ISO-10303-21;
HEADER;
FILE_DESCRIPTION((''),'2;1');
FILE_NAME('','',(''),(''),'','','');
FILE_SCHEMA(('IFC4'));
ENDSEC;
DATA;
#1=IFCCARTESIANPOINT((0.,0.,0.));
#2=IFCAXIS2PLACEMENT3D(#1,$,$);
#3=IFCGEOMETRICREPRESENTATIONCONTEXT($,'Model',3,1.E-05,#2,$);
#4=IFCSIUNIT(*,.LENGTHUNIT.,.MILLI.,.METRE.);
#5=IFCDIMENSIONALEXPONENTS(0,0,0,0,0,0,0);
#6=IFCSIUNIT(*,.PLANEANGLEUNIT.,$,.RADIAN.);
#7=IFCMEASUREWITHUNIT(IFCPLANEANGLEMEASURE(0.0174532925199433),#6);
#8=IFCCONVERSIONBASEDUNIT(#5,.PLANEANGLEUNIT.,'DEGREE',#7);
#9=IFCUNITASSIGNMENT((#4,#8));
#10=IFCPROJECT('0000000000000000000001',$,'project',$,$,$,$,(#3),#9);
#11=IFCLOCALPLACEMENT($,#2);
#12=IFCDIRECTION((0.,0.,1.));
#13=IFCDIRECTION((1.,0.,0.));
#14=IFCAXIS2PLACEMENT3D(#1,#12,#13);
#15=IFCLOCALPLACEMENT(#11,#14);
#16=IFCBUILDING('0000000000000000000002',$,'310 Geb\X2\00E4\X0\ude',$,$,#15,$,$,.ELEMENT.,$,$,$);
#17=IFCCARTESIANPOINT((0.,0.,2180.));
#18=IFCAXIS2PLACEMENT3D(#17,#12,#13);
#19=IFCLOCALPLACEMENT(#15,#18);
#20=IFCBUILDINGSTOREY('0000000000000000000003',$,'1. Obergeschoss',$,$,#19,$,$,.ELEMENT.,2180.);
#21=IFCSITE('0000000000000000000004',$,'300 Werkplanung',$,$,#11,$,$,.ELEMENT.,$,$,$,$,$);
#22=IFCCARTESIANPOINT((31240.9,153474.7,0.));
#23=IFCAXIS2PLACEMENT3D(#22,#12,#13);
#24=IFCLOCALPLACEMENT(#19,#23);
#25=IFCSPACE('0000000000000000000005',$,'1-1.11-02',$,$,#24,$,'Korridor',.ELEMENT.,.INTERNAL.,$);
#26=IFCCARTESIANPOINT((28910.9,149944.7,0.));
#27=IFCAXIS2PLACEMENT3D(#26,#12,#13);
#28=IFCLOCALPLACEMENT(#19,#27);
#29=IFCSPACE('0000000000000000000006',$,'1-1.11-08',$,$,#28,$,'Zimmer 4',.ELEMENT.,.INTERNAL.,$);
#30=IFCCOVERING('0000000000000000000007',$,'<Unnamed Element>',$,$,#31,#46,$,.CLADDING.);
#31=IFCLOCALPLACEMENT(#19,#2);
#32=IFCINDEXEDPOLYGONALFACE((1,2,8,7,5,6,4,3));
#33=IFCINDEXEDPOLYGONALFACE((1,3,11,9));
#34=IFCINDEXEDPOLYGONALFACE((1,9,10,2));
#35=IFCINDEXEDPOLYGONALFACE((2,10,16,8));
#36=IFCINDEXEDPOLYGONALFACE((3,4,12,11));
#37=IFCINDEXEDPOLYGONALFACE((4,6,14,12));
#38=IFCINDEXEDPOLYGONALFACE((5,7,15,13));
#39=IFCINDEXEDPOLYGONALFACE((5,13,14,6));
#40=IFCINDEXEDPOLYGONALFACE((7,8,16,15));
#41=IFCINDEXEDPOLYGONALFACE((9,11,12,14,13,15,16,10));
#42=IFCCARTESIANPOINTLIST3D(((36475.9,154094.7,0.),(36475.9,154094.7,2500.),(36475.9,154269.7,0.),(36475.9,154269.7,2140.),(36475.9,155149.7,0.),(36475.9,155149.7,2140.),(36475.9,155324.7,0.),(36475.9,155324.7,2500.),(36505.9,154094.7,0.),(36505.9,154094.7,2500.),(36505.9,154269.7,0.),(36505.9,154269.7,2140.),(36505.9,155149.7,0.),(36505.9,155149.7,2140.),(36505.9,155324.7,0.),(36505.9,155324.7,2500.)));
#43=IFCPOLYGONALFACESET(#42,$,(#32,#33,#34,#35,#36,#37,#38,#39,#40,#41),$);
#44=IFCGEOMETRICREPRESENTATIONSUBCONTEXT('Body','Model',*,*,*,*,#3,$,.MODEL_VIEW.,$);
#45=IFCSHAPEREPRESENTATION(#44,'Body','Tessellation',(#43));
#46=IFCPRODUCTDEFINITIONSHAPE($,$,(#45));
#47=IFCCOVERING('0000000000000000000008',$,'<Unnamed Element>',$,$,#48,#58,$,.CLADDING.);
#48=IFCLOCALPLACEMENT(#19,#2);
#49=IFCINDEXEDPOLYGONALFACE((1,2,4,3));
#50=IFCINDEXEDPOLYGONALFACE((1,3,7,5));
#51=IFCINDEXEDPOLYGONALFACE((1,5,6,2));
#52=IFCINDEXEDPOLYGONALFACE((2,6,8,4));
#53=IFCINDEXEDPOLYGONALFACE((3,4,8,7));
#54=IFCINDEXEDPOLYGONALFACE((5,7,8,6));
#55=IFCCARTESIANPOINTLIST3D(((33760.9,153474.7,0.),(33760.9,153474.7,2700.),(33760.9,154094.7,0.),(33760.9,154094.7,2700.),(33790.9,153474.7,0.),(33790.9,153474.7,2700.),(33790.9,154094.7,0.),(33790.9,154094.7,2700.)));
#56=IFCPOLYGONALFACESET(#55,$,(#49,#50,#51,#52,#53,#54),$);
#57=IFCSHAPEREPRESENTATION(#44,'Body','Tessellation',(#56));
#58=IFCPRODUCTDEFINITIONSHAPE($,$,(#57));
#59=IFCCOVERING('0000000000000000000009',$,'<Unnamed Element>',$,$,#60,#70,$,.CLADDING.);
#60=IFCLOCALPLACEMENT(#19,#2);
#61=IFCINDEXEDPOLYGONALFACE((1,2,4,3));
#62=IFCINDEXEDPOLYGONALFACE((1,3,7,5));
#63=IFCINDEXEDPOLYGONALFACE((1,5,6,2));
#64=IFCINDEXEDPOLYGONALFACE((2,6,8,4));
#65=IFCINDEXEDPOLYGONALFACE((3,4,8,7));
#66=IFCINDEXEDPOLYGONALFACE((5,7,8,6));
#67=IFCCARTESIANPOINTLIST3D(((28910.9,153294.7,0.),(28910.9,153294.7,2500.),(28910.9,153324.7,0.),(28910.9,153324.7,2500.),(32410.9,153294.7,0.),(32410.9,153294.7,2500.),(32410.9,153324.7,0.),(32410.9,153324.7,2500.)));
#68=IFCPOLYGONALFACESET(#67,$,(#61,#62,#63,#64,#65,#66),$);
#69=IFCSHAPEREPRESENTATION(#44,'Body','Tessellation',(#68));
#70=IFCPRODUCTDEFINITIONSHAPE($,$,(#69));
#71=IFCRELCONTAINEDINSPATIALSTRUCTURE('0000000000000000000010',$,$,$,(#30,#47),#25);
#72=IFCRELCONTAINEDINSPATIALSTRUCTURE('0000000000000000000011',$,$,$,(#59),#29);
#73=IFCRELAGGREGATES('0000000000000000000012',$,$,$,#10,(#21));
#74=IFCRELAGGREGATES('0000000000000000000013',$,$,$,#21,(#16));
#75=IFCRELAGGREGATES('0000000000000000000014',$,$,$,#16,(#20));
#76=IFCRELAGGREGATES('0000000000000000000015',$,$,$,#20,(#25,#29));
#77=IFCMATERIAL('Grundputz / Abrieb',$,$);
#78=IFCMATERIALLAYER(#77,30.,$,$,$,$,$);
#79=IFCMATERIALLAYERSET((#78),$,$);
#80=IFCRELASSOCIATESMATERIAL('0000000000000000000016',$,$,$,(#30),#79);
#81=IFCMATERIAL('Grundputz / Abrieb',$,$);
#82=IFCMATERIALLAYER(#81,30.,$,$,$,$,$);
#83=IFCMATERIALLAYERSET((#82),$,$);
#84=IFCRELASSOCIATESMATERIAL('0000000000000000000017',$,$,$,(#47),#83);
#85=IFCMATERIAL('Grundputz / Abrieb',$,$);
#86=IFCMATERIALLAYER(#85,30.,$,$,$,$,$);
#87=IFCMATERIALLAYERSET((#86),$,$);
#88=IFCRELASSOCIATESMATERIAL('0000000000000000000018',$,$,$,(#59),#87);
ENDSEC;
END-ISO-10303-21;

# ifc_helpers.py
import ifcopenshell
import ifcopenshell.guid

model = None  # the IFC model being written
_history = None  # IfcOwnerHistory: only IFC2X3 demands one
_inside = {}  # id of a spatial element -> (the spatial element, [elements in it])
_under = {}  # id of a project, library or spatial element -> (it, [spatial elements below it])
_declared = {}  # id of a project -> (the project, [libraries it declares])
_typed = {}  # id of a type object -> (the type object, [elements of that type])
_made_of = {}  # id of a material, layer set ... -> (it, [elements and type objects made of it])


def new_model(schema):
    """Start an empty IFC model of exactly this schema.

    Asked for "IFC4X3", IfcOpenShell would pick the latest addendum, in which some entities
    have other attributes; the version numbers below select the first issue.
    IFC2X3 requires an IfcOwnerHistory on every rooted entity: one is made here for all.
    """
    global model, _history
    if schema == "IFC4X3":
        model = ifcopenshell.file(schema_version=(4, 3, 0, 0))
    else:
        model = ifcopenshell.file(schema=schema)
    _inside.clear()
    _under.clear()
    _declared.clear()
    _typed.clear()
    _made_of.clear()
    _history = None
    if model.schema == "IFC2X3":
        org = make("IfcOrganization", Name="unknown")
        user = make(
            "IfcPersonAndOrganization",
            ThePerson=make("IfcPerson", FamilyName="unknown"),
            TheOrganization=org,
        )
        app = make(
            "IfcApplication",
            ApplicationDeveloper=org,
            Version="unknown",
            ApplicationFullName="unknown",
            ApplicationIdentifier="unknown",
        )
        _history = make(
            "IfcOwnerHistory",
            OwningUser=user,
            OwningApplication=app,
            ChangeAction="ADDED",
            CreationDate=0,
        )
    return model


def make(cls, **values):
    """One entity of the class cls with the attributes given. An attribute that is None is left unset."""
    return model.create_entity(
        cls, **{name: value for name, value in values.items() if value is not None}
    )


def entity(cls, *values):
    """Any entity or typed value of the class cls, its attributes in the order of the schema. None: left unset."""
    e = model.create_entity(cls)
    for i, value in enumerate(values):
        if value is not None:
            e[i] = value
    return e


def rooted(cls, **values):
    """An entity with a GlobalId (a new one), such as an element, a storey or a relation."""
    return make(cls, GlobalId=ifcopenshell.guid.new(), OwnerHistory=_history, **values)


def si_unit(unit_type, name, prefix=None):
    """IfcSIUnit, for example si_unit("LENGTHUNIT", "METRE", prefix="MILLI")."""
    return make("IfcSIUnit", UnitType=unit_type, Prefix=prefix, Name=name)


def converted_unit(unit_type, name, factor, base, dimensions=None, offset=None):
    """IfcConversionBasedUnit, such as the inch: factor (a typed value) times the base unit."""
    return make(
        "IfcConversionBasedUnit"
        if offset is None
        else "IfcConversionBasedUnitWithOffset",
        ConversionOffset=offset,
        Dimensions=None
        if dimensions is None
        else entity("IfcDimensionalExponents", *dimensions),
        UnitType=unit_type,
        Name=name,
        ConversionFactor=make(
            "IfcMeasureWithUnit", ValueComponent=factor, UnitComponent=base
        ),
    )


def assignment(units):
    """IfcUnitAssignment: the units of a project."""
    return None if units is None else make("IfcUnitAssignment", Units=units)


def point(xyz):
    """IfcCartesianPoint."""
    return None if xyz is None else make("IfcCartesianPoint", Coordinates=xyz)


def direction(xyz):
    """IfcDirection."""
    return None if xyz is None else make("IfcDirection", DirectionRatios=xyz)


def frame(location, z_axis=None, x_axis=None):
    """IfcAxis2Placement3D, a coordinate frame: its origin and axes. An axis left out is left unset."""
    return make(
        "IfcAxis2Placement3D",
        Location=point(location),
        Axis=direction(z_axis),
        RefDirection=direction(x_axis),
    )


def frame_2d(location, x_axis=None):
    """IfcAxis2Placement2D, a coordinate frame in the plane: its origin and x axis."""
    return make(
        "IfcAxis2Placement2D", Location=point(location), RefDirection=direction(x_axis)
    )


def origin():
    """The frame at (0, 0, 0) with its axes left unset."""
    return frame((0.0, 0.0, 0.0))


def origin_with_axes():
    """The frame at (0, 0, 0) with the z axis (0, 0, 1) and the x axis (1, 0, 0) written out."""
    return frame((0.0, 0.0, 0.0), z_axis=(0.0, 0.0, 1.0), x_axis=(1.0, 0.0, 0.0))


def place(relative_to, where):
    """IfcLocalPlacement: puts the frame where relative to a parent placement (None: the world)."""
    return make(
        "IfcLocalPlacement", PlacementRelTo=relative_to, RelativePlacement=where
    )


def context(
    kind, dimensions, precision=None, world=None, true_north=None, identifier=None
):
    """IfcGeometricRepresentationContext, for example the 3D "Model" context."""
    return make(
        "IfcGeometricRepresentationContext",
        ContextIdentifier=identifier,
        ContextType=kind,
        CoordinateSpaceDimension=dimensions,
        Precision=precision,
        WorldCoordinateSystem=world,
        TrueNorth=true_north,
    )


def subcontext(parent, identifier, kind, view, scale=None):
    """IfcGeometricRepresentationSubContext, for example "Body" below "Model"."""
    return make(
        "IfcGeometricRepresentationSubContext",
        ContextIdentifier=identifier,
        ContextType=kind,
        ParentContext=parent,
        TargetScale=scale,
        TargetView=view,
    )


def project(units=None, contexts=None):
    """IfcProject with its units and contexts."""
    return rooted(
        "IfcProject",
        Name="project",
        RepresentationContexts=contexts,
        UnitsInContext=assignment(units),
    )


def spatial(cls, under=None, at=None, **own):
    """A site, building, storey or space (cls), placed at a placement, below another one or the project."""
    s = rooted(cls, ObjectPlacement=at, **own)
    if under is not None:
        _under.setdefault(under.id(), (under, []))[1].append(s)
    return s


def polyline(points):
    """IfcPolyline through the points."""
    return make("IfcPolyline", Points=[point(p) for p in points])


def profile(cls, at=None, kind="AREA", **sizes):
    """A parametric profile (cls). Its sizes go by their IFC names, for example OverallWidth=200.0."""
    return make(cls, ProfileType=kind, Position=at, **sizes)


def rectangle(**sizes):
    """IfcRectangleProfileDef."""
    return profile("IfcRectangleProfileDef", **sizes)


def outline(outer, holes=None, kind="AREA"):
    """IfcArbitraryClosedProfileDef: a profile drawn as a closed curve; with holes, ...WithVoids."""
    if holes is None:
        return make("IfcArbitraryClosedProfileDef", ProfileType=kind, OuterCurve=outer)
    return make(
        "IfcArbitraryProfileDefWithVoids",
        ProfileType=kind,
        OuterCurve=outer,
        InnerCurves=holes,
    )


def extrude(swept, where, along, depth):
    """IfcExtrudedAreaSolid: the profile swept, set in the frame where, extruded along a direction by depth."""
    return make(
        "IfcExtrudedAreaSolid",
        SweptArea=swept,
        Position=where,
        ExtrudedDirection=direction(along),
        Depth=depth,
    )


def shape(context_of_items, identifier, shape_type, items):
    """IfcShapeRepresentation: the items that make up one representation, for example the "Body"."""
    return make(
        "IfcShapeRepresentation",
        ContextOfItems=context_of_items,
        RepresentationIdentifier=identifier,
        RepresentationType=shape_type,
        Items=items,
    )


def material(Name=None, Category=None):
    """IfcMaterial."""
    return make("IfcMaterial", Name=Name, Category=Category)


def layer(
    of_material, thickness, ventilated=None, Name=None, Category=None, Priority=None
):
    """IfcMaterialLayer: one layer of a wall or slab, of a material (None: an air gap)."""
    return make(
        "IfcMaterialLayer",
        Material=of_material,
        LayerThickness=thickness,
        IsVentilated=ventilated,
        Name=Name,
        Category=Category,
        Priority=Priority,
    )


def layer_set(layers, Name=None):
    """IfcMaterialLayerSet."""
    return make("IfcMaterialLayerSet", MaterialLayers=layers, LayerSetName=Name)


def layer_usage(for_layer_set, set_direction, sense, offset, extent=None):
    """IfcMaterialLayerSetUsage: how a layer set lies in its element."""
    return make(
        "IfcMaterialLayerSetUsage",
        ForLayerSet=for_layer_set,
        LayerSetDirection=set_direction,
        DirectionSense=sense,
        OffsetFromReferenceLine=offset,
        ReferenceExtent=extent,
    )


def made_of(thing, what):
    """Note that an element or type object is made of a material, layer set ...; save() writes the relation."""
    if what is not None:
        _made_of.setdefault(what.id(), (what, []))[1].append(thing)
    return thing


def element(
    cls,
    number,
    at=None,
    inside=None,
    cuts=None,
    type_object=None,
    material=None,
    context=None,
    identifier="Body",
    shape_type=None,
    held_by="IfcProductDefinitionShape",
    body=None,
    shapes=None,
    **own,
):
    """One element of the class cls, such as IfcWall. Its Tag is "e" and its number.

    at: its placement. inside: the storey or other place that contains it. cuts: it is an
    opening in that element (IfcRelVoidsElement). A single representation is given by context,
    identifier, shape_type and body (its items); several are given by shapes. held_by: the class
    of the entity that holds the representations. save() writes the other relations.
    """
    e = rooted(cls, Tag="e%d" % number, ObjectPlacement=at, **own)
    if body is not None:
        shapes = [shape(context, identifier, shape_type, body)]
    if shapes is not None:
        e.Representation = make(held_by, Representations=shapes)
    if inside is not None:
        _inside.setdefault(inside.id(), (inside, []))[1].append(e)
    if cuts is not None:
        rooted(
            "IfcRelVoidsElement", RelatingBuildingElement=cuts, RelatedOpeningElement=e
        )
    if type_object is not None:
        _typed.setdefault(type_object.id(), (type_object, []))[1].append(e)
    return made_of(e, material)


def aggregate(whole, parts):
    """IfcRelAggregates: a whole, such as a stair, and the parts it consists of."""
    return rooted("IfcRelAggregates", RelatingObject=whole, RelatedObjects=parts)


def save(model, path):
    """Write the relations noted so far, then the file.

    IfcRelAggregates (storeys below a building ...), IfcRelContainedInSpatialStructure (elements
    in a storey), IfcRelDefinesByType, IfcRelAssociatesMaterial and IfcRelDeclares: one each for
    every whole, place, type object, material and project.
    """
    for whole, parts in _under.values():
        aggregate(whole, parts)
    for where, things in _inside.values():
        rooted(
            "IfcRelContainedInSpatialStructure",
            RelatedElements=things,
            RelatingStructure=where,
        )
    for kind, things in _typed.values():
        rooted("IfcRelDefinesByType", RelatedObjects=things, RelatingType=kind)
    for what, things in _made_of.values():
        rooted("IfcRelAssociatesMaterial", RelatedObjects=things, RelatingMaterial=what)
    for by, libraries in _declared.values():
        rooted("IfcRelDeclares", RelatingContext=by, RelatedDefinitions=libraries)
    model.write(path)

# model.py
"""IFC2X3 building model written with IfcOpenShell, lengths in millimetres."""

from ifc_helpers import new_model, entity, si_unit, converted_unit, frame, frame_2d, origin, origin_with_axes, place, context, subcontext, project, spatial, polyline, rectangle, outline, extrude, material, layer, layer_set, layer_usage, element, save


model = new_model("IFC2X3")

# Units and contexts
model_context = context("Model", 3, precision=1e-05, world=origin())
body_context = subcontext(model_context, "Body", "Model", "MODEL_VIEW")
ifc_project = project(units=[si_unit("LENGTHUNIT", "METRE", prefix="MILLI"), converted_unit("PLANEANGLEUNIT", "DEGREE", entity("IfcPlaneAngleMeasure", 0.0174532925199433), si_unit("PLANEANGLEUNIT", "RADIAN"), dimensions=[0, 0, 0, 0, 0, 0, 0])], contexts=[model_context])

# Site, building, storey
site_placement = place(None, origin())
site = spatial("IfcSite", under=ifc_project, at=site_placement, Name="300 Werkplanung", CompositionType="ELEMENT")
building_placement = place(site_placement, origin_with_axes())
building = spatial("IfcBuilding", under=site, at=building_placement, Name="310 Gebäude", CompositionType="ELEMENT")
storey_placement = place(building_placement, frame((0.0, 0.0, 2180.0), z_axis=(0.0, 0.0, 1.0), x_axis=(1.0, 0.0, 0.0)))
storey = spatial("IfcBuildingStorey", under=building, at=storey_placement, Name="1. Obergeschoss", CompositionType="ELEMENT", Elevation=2180.0)

# Shared definitions
space_1_placement = place(storey_placement, frame((31240.9, 153474.7, 0.0), z_axis=(0.0, 0.0, 1.0), x_axis=(1.0, 0.0, 0.0)))
space_1 = spatial("IfcSpace", under=storey, at=space_1_placement, Name="1-1.11-02", LongName="Korridor", CompositionType="ELEMENT", InteriorOrExteriorSpace="INTERNAL")

# Coverings
ifc_material_1 = material(Name="Grundputz / Abrieb")
ifc_layer_1 = layer(ifc_material_1, 30.0)
ifc_layer_set_1 = layer_set([ifc_layer_1])
ifc_layer_usage_1 = layer_usage(ifc_layer_set_1, "AXIS3", "POSITIVE", 0.0)
covering_1_placement = place(space_1_placement, frame((5265.0, 620.0, 0.0), z_axis=(0.0, 0.0, 1.0), x_axis=(0.0, 1.0, 0.0)))
element("IfcCovering", 1, at=covering_1_placement, inside=space_1, material=ifc_layer_usage_1, Name="<Unnamed Element>", PredefinedType="CLADDING", context=body_context, shape_type="SweptSolid", body=[
    extrude(outline(polyline([(1230.0, 0.0), (1230.0, -2500.0), (0.0, -2500.0), (0.0, 0.0), (175.0, 0.0), (175.0, -2140.0), (1055.0, -2140.0), (1055.0, 0.0), (1230.0, 0.0)])), frame((0.0, 0.0, 0.0), z_axis=(0.0, 1.0, 0.0), x_axis=(1.0, 0.0, 0.0)), (0.0, 0.0, 1.0), 30.0),
])
ifc_material_2 = material(Name="Grundputz / Abrieb")
ifc_layer_2 = layer(ifc_material_2, 30.0)
ifc_layer_set_2 = layer_set([ifc_layer_2])
ifc_layer_usage_2 = layer_usage(ifc_layer_set_2, "AXIS3", "POSITIVE", 0.0)
covering_2_placement = place(space_1_placement, frame((2550.0, 0.0, 0.0), z_axis=(0.0, 0.0, 1.0), x_axis=(0.0, 1.0, 0.0)))
element("IfcCovering", 2, at=covering_2_placement, inside=space_1, material=ifc_layer_usage_2, Name="<Unnamed Element>", PredefinedType="CLADDING", context=body_context, shape_type="SweptSolid", body=[
    extrude(rectangle(XDim=2700.0, YDim=620.0, at=frame_2d((-310.0, 1350.0), x_axis=(0.0, 1.0))), frame((620.0, 0.0, 2700.0), z_axis=(0.0, 1.0, 0.0), x_axis=(1.0, 0.0, 0.0)), (0.0, 0.0, 1.0), 30.0),
])

# Shared definitions
space_2_placement = place(storey_placement, frame((28910.9, 149944.7, 0.0), z_axis=(0.0, 0.0, 1.0), x_axis=(1.0, 0.0, 0.0)))
space_2 = spatial("IfcSpace", under=storey, at=space_2_placement, Name="1-1.11-08", LongName="Zimmer 4", CompositionType="ELEMENT", InteriorOrExteriorSpace="INTERNAL")

# Covering
ifc_material_3 = material(Name="Grundputz / Abrieb")
ifc_layer_3 = layer(ifc_material_3, 30.0)
ifc_layer_set_3 = layer_set([ifc_layer_3])
ifc_layer_usage_3 = layer_usage(ifc_layer_set_3, "AXIS3", "POSITIVE", 0.0)
covering_3_placement = place(space_2_placement, frame((3500.0, 3380.0, 0.0), z_axis=(0.0, 0.0, 1.0), x_axis=(-1.0, 0.0, 0.0)))
element("IfcCovering", 3, at=covering_3_placement, inside=space_2, material=ifc_layer_usage_3, Name="<Unnamed Element>", PredefinedType="CLADDING", context=body_context, shape_type="SweptSolid", body=[
    extrude(rectangle(XDim=2500.0, YDim=3500.0, at=frame_2d((-1750.0, 1250.0), x_axis=(0.0, 1.0))), frame((3500.0, 0.0, 2500.0), z_axis=(0.0, 1.0, 0.0), x_axis=(1.0, 0.0, 0.0)), (0.0, 0.0, 1.0), 30.0),
])

save(model, "model.ifc")
